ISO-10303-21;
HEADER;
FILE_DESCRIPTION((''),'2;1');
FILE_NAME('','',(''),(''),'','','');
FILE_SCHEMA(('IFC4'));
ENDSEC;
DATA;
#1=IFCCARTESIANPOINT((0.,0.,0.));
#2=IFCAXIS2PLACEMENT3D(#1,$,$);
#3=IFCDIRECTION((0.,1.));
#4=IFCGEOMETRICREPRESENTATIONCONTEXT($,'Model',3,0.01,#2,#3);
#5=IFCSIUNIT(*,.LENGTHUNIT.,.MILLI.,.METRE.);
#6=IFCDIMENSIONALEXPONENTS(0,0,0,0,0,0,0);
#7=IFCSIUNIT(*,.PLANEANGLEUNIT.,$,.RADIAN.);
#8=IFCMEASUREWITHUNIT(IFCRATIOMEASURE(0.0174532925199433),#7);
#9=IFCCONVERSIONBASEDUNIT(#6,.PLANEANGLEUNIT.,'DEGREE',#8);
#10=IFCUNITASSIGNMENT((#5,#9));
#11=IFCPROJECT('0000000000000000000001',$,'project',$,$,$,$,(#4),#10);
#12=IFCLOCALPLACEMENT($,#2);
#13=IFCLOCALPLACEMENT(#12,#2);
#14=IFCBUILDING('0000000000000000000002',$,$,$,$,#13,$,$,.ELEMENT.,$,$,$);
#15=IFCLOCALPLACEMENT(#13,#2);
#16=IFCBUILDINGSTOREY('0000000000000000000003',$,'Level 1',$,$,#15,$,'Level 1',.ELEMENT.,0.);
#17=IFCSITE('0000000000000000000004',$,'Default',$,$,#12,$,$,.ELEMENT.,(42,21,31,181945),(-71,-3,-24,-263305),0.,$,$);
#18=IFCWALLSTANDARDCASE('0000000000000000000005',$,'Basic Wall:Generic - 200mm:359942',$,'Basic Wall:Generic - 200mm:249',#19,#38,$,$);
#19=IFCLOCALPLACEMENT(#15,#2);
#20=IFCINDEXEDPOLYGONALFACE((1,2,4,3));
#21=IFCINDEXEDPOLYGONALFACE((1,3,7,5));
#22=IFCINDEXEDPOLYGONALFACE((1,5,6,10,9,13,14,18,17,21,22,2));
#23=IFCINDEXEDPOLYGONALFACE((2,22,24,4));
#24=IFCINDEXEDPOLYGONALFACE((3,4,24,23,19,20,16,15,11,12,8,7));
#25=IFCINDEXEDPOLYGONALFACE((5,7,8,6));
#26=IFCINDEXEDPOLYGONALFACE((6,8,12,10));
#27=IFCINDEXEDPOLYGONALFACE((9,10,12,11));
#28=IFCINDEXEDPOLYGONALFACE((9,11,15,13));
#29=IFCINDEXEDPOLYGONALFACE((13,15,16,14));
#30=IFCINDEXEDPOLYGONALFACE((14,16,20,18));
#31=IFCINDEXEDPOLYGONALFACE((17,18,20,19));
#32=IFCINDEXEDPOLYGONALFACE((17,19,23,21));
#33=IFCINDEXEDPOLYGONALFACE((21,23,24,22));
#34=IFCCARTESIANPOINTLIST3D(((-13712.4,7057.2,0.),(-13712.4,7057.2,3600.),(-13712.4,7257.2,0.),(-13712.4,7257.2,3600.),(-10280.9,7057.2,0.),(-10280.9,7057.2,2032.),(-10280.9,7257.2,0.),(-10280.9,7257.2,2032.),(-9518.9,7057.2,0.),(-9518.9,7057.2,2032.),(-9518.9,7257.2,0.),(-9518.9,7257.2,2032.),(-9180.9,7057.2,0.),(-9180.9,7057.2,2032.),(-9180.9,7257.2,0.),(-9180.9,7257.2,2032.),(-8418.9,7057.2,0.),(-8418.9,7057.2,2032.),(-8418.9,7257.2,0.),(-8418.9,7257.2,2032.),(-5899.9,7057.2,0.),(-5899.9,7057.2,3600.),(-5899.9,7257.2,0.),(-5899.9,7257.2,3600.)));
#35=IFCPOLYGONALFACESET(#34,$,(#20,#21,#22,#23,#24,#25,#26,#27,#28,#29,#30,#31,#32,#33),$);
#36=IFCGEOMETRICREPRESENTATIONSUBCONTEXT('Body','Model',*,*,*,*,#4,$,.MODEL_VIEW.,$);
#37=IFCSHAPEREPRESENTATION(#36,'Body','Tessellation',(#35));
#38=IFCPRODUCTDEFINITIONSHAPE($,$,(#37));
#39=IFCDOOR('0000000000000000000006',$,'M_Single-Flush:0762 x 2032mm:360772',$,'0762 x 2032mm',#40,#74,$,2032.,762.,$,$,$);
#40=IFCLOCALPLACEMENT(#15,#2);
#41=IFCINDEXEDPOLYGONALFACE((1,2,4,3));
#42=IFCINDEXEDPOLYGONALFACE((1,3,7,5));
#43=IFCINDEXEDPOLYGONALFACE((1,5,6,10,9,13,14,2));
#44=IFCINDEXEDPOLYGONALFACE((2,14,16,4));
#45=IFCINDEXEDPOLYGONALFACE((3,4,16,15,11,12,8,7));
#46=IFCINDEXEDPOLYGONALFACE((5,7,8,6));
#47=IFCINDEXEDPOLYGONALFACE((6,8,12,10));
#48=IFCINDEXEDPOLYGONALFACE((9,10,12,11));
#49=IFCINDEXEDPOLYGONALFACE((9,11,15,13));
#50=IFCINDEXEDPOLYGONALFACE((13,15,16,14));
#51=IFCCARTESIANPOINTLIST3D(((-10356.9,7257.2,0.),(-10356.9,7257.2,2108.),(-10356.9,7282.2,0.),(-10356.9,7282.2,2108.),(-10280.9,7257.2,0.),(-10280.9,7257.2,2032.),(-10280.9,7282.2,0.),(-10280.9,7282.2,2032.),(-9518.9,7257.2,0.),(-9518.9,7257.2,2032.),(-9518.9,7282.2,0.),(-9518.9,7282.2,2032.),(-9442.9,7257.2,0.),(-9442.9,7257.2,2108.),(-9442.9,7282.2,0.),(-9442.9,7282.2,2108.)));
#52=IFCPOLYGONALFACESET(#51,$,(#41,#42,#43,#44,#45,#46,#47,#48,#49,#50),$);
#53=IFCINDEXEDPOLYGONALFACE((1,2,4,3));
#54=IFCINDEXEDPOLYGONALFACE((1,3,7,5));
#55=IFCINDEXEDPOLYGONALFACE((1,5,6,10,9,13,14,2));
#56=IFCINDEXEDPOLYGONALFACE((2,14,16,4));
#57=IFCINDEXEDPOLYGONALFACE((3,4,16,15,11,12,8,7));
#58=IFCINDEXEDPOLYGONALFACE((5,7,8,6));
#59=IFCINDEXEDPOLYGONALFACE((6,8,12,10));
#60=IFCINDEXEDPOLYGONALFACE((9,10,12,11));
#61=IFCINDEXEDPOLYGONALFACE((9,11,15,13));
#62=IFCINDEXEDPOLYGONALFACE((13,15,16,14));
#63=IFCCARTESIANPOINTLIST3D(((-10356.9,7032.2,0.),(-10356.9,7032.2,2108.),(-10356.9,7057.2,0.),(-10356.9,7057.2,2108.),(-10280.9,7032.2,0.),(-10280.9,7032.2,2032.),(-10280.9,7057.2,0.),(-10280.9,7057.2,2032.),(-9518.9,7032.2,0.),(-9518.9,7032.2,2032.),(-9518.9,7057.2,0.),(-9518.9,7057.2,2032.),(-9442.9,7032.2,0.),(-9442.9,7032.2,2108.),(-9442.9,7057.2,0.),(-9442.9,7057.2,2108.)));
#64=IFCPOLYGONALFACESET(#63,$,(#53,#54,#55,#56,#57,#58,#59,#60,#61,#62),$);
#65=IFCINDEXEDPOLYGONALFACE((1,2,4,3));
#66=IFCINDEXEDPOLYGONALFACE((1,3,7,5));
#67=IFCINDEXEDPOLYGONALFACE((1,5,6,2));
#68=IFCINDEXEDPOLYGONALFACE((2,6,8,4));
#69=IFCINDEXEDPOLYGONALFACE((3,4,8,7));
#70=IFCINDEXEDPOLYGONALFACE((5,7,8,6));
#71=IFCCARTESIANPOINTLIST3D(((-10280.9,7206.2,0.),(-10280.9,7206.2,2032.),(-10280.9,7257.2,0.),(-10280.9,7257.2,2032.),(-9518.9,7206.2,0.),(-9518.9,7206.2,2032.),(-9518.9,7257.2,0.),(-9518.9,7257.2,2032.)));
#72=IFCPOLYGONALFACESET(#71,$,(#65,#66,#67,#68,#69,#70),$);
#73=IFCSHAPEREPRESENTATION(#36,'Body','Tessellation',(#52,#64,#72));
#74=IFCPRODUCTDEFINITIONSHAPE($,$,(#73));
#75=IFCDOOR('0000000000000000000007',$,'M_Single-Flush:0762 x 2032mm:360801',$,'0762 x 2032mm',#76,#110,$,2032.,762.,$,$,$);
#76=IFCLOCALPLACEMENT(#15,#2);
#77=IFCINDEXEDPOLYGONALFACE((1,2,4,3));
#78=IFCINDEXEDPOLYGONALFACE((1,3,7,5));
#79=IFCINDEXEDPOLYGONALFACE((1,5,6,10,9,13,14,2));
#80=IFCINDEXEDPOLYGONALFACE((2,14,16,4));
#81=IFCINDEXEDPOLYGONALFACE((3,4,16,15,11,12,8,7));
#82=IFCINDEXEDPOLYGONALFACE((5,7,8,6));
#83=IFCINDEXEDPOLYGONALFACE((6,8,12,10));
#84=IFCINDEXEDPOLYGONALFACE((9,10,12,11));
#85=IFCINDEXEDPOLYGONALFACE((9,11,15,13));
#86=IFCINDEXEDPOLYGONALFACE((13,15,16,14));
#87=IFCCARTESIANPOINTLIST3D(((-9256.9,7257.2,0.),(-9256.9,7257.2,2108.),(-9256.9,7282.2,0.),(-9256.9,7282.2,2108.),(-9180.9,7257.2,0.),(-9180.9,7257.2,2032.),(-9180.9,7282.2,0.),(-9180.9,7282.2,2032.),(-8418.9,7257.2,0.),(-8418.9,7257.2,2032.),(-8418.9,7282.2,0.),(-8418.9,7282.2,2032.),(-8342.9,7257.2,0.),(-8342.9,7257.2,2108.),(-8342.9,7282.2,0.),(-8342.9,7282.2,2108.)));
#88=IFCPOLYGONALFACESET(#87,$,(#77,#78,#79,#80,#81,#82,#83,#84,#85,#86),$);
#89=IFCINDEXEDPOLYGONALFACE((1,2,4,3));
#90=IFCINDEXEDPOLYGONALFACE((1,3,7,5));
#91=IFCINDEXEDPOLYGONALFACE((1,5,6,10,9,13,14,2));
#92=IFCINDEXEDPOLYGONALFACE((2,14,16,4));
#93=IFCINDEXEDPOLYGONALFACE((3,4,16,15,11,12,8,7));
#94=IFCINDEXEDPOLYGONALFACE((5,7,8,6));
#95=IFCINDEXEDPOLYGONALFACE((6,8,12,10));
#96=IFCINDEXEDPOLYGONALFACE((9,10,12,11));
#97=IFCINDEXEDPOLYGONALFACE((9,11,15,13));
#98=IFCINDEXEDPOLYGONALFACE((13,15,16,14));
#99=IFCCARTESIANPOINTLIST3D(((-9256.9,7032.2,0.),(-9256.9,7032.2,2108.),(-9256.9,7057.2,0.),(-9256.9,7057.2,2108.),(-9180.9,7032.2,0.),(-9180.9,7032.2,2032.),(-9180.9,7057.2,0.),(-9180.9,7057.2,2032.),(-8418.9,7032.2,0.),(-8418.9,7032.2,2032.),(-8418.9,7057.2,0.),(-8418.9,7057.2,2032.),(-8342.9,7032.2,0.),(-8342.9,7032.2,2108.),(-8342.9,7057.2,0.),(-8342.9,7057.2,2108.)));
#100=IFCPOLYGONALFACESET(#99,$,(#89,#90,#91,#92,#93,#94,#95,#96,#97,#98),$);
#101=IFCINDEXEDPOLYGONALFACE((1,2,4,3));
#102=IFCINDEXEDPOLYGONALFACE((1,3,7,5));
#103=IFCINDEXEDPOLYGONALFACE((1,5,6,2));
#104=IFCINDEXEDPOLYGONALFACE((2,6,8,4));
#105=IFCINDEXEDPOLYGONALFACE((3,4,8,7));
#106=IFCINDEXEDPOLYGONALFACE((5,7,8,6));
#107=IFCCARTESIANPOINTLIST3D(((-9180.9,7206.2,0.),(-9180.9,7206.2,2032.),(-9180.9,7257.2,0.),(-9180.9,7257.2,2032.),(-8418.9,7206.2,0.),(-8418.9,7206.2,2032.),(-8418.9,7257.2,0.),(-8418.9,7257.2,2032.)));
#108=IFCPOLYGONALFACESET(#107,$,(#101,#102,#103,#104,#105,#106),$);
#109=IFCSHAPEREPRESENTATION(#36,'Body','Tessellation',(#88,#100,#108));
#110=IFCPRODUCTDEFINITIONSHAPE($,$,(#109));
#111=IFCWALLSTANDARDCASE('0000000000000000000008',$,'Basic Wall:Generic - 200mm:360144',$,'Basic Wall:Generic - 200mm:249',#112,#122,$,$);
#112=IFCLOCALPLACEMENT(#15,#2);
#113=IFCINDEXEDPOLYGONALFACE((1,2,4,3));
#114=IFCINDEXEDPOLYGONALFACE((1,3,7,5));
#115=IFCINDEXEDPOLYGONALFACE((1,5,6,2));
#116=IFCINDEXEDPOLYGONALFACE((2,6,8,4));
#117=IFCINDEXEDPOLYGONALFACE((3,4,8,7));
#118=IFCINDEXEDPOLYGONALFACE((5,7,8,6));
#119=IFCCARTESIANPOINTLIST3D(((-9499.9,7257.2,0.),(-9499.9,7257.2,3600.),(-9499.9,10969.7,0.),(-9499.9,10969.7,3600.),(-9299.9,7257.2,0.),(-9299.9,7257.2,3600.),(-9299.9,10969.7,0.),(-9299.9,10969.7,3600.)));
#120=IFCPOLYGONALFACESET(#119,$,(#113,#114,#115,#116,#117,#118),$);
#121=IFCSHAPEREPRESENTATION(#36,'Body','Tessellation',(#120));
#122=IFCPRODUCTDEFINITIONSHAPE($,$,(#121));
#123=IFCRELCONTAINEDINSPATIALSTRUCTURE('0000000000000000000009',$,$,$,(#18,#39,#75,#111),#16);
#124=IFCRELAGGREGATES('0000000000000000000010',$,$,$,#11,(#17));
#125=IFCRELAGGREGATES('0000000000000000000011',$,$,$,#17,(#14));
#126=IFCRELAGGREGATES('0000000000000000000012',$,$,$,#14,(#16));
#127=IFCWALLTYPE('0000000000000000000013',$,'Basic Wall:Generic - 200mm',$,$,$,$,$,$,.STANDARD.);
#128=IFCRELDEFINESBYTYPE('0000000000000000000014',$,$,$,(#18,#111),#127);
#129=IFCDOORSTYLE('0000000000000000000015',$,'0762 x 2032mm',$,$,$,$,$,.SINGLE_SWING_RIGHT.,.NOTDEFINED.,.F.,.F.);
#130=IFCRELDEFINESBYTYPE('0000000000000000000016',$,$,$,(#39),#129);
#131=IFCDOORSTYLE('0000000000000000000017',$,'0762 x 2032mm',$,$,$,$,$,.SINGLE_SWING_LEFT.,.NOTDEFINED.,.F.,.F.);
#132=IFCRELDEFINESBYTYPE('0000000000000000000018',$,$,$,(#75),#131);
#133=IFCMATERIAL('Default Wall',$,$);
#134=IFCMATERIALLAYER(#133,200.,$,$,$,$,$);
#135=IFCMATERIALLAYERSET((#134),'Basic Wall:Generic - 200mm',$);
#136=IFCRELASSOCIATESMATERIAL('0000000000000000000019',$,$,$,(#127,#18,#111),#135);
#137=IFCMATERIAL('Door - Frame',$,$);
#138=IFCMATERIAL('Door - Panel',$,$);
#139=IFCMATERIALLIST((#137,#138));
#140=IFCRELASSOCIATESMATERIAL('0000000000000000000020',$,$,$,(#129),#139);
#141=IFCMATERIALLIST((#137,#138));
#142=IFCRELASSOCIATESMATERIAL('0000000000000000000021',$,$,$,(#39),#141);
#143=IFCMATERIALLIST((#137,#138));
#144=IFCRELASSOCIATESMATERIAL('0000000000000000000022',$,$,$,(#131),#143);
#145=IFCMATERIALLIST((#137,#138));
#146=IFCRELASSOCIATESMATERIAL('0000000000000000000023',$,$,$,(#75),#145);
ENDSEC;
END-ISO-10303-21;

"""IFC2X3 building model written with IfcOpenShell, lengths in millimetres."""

from ifc_helpers import new_model, entity, si_unit, converted_unit, direction, frame, frame_2d, origin, place, context, subcontext, project, spatial, polyline, rectangle, outline, extrude, clip, bounded_halfspace, source, transform, mapped, material, material_list, layer, layer_set, layer_usage, type_object, type_shapes, element, fill, save


model = new_model("IFC2X3")

# Units and contexts
model_context = context("Model", 3, precision=0.01, world=origin(), true_north=direction((0.0, 1.0)))
body_context = subcontext(model_context, "Body", "Model", "MODEL_VIEW")
ifc_project = project(units=[si_unit("LENGTHUNIT", "METRE", prefix="MILLI"), converted_unit("PLANEANGLEUNIT", "DEGREE", entity("IfcRatioMeasure", 0.0174532925199433), si_unit("PLANEANGLEUNIT", "RADIAN"), dimensions=[0, 0, 0, 0, 0, 0, 0])], contexts=[model_context])

# Site, building, storey
site_placement = place(None, origin())
site = spatial("IfcSite", under=ifc_project, at=site_placement, Name="Default", CompositionType="ELEMENT", RefLatitude=(42, 21, 31, 181945), RefLongitude=(-71, -3, -24, -263305), RefElevation=0.0)
building_placement = place(site_placement, origin())
building = spatial("IfcBuilding", under=site, at=building_placement, CompositionType="ELEMENT")
storey_placement = place(building_placement, origin())
storey = spatial("IfcBuildingStorey", under=building, at=storey_placement, Name="Level 1", LongName="Level 1", CompositionType="ELEMENT", Elevation=0.0)

# Shared definitions
ifc_material_1 = material(Name="Default Wall")

# Wall, openings, doors
ifc_layer_1 = layer(ifc_material_1, 200.0)
ifc_layer_set_1 = layer_set([ifc_layer_1], Name="Basic Wall:Generic - 200mm")
ifc_layer_usage_1 = layer_usage(ifc_layer_set_1, "AXIS2", "NEGATIVE", 100.0)
wall_type_1 = type_object("IfcWallType", Name="Basic Wall:Generic - 200mm", PredefinedType="STANDARD", material=ifc_layer_set_1)
wall_1_placement = place(storey_placement, frame((-13712.4, 7157.2, 0.0)))
wall_1 = element("IfcWallStandardCase", 1, at=wall_1_placement, inside=storey, type_object=wall_type_1, material=ifc_layer_usage_1, Name="Basic Wall:Generic - 200mm:359942", ObjectType="Basic Wall:Generic - 200mm:249", context=body_context, shape_type="Clipping", body=[
    clip(extrude(rectangle(XDim=7812.5, YDim=200.0, at=frame_2d((3906.2, 0.0), x_axis=(-1.0, 0.0))), origin(), (0.0, 0.0, 1.0), 3600.0), bounded_halfspace(frame((0.0, -100.0, 3600.0), z_axis=(0.0, 0.0, -1.0), x_axis=(1.0, 0.0, 0.0)), True, frame((0.0, -100.0, 3600.0)), polyline([(0.0, 0.0), (3212.5, 0.0), (3412.5, 0.0), (7625.0, 0.0), (7812.5, 0.0), (7812.5, 200.0), (4412.5, 200.0), (4212.5, 200.0), (0.0, 200.0), (0.0, 0.0)]))),
])
opening_1_placement = place(wall_1_placement, frame((3431.5, -100.0, 0.0)))
opening_1 = element("IfcOpeningElement", 2, at=opening_1_placement, cuts=wall_1, ObjectType="Opening", context=body_context, shape_type="SweptSolid", body=[
    extrude(rectangle(XDim=762.0, YDim=2032.0, at=frame_2d((1016.0, 381.0), x_axis=(0.0, 1.0))), frame((0.0, 0.0, 0.0), z_axis=(0.0, 1.0, 0.0), x_axis=(0.0, 0.0, 1.0)), (0.0, 0.0, 1.0), 200.0),
])
opening_2_placement = place(wall_1_placement, frame((4531.5, -100.0, 0.0)))
opening_2 = element("IfcOpeningElement", 3, at=opening_2_placement, cuts=wall_1, ObjectType="Opening", context=body_context, shape_type="SweptSolid", body=[
    extrude(rectangle(XDim=762.0, YDim=2032.0, at=frame_2d((1016.0, 381.0), x_axis=(0.0, -1.0))), frame((0.0, 0.0, 0.0), z_axis=(0.0, 1.0, 0.0), x_axis=(0.0, 0.0, 1.0)), (0.0, 0.0, 1.0), 200.0),
])
ifc_material_2 = material(Name="Door - Frame")
ifc_material_3 = material(Name="Door - Panel")
ifc_material_list_1 = material_list([ifc_material_2, ifc_material_3])
ifc_material_list_2 = material_list([ifc_material_2, ifc_material_3])
door_style_1 = type_object("IfcDoorStyle", Name="0762 x 2032mm", ConstructionType="NOTDEFINED", OperationType="SINGLE_SWING_RIGHT", ParameterTakesPrecedence=False, Sizeable=False, material=ifc_material_list_2)
shared_shape_1 = source(origin(), body_context, "Body", "SweptSolid", [
    extrude(outline(polyline([(-457.0, -1073.0), (457.0, -1073.0), (457.0, 1035.0), (381.0, 1035.0), (381.0, -997.0), (-381.0, -997.0), (-381.0, 1035.0), (-457.0, 1035.0), (-457.0, -1073.0)])), frame((381.0, 200.0, 1035.0), z_axis=(0.0, 1.0, 0.0), x_axis=(1.0, 0.0, 0.0)), (0.0, 0.0, 1.0), 25.0),
    extrude(outline(polyline([(-1073.0, -457.0), (1035.0, -457.0), (1035.0, -381.0), (-997.0, -381.0), (-997.0, 381.0), (1035.0, 381.0), (1035.0, 457.0), (-1073.0, 457.0), (-1073.0, -457.0)])), frame((381.0, -25.0, 1035.0), z_axis=(0.0, 1.0, 0.0), x_axis=(0.0, 0.0, -1.0)), (0.0, 0.0, 1.0), 25.0),
    extrude(rectangle(XDim=51.0, YDim=762.0, at=frame_2d((0.0, 0.0), x_axis=(1.0, 0.0))), frame((381.0, 174.5, 0.0), z_axis=(0.0, 0.0, 1.0), x_axis=(0.0, 1.0, 0.0)), (0.0, 0.0, 1.0), 2032.0),
])
type_shapes(door_style_1, [shared_shape_1])
door_1_placement = place(opening_1_placement, origin())
door_1 = element("IfcDoor", 4, at=door_1_placement, inside=storey, type_object=door_style_1, material=ifc_material_list_1, Name="M_Single-Flush:0762 x 2032mm:360772", ObjectType="0762 x 2032mm", OverallHeight=2032.0, OverallWidth=762.0, context=body_context, shape_type="MappedRepresentation", body=[
    mapped(shared_shape_1, transform((0.0, 0.0, 0.0), scale=1.0)),
])
fill(opening_1, door_1)
ifc_material_list_3 = material_list([ifc_material_2, ifc_material_3])
ifc_material_list_4 = material_list([ifc_material_2, ifc_material_3])
door_style_2 = type_object("IfcDoorStyle", Name="0762 x 2032mm", ConstructionType="NOTDEFINED", OperationType="SINGLE_SWING_LEFT", ParameterTakesPrecedence=False, Sizeable=False, material=ifc_material_list_4)
shared_shape_2 = source(origin(), body_context, "Body", "SweptSolid", [
    extrude(outline(polyline([(-457.0, -1073.0), (457.0, -1073.0), (457.0, 1035.0), (381.0, 1035.0), (381.0, -997.0), (-381.0, -997.0), (-381.0, 1035.0), (-457.0, 1035.0), (-457.0, -1073.0)])), frame((381.0, 225.0, 1035.0), z_axis=(0.0, -1.0, 0.0), x_axis=(-1.0, 0.0, 0.0)), (0.0, 0.0, 1.0), 25.0),
    extrude(outline(polyline([(-1073.0, -457.0), (1035.0, -457.0), (1035.0, -381.0), (-997.0, -381.0), (-997.0, 381.0), (1035.0, 381.0), (1035.0, 457.0), (-1073.0, 457.0), (-1073.0, -457.0)])), frame((381.0, 0.0, 1035.0), z_axis=(0.0, -1.0, 0.0), x_axis=(0.0, 0.0, -1.0)), (0.0, 0.0, 1.0), 25.0),
    extrude(rectangle(XDim=762.0, YDim=51.0, at=frame_2d((0.0, 0.0), x_axis=(1.0, 0.0))), frame((381.0, 174.5, 0.0)), (0.0, 0.0, 1.0), 2032.0),
])
type_shapes(door_style_2, [shared_shape_2])
door_2_placement = place(opening_2_placement, origin())
door_2 = element("IfcDoor", 5, at=door_2_placement, inside=storey, type_object=door_style_2, material=ifc_material_list_3, Name="M_Single-Flush:0762 x 2032mm:360801", ObjectType="0762 x 2032mm", OverallHeight=2032.0, OverallWidth=762.0, context=body_context, shape_type="MappedRepresentation", body=[
    mapped(shared_shape_2, transform((0.0, 0.0, 0.0), scale=1.0)),
])
fill(opening_2, door_2)

# Wall
ifc_layer_usage_2 = layer_usage(ifc_layer_set_1, "AXIS2", "NEGATIVE", 100.0)
wall_2_placement = place(storey_placement, frame((-9399.9, 7257.2, 0.0), z_axis=(0.0, 0.0, 1.0), x_axis=(0.0, 1.0, 0.0)))
element("IfcWallStandardCase", 6, at=wall_2_placement, inside=storey, type_object=wall_type_1, material=ifc_layer_usage_2, Name="Basic Wall:Generic - 200mm:360144", ObjectType="Basic Wall:Generic - 200mm:249", context=body_context, shape_type="Clipping", body=[
    clip(extrude(rectangle(XDim=3712.5, YDim=200.0, at=frame_2d((1856.3, 0.0), x_axis=(-1.0, 0.0))), origin(), (0.0, 0.0, 1.0), 3600.0), bounded_halfspace(frame((0.0, -100.0, 3600.0), z_axis=(0.0, 0.0, -1.0), x_axis=(0.0, -1.0, 0.0)), True, frame((0.0, -100.0, 3600.0)), polyline([(0.0, 0.0), (3712.5, 0.0), (3712.5, 200.0), (0.0, 200.0), (0.0, 0.0)]))),
])

save(model, "model.ifc")
